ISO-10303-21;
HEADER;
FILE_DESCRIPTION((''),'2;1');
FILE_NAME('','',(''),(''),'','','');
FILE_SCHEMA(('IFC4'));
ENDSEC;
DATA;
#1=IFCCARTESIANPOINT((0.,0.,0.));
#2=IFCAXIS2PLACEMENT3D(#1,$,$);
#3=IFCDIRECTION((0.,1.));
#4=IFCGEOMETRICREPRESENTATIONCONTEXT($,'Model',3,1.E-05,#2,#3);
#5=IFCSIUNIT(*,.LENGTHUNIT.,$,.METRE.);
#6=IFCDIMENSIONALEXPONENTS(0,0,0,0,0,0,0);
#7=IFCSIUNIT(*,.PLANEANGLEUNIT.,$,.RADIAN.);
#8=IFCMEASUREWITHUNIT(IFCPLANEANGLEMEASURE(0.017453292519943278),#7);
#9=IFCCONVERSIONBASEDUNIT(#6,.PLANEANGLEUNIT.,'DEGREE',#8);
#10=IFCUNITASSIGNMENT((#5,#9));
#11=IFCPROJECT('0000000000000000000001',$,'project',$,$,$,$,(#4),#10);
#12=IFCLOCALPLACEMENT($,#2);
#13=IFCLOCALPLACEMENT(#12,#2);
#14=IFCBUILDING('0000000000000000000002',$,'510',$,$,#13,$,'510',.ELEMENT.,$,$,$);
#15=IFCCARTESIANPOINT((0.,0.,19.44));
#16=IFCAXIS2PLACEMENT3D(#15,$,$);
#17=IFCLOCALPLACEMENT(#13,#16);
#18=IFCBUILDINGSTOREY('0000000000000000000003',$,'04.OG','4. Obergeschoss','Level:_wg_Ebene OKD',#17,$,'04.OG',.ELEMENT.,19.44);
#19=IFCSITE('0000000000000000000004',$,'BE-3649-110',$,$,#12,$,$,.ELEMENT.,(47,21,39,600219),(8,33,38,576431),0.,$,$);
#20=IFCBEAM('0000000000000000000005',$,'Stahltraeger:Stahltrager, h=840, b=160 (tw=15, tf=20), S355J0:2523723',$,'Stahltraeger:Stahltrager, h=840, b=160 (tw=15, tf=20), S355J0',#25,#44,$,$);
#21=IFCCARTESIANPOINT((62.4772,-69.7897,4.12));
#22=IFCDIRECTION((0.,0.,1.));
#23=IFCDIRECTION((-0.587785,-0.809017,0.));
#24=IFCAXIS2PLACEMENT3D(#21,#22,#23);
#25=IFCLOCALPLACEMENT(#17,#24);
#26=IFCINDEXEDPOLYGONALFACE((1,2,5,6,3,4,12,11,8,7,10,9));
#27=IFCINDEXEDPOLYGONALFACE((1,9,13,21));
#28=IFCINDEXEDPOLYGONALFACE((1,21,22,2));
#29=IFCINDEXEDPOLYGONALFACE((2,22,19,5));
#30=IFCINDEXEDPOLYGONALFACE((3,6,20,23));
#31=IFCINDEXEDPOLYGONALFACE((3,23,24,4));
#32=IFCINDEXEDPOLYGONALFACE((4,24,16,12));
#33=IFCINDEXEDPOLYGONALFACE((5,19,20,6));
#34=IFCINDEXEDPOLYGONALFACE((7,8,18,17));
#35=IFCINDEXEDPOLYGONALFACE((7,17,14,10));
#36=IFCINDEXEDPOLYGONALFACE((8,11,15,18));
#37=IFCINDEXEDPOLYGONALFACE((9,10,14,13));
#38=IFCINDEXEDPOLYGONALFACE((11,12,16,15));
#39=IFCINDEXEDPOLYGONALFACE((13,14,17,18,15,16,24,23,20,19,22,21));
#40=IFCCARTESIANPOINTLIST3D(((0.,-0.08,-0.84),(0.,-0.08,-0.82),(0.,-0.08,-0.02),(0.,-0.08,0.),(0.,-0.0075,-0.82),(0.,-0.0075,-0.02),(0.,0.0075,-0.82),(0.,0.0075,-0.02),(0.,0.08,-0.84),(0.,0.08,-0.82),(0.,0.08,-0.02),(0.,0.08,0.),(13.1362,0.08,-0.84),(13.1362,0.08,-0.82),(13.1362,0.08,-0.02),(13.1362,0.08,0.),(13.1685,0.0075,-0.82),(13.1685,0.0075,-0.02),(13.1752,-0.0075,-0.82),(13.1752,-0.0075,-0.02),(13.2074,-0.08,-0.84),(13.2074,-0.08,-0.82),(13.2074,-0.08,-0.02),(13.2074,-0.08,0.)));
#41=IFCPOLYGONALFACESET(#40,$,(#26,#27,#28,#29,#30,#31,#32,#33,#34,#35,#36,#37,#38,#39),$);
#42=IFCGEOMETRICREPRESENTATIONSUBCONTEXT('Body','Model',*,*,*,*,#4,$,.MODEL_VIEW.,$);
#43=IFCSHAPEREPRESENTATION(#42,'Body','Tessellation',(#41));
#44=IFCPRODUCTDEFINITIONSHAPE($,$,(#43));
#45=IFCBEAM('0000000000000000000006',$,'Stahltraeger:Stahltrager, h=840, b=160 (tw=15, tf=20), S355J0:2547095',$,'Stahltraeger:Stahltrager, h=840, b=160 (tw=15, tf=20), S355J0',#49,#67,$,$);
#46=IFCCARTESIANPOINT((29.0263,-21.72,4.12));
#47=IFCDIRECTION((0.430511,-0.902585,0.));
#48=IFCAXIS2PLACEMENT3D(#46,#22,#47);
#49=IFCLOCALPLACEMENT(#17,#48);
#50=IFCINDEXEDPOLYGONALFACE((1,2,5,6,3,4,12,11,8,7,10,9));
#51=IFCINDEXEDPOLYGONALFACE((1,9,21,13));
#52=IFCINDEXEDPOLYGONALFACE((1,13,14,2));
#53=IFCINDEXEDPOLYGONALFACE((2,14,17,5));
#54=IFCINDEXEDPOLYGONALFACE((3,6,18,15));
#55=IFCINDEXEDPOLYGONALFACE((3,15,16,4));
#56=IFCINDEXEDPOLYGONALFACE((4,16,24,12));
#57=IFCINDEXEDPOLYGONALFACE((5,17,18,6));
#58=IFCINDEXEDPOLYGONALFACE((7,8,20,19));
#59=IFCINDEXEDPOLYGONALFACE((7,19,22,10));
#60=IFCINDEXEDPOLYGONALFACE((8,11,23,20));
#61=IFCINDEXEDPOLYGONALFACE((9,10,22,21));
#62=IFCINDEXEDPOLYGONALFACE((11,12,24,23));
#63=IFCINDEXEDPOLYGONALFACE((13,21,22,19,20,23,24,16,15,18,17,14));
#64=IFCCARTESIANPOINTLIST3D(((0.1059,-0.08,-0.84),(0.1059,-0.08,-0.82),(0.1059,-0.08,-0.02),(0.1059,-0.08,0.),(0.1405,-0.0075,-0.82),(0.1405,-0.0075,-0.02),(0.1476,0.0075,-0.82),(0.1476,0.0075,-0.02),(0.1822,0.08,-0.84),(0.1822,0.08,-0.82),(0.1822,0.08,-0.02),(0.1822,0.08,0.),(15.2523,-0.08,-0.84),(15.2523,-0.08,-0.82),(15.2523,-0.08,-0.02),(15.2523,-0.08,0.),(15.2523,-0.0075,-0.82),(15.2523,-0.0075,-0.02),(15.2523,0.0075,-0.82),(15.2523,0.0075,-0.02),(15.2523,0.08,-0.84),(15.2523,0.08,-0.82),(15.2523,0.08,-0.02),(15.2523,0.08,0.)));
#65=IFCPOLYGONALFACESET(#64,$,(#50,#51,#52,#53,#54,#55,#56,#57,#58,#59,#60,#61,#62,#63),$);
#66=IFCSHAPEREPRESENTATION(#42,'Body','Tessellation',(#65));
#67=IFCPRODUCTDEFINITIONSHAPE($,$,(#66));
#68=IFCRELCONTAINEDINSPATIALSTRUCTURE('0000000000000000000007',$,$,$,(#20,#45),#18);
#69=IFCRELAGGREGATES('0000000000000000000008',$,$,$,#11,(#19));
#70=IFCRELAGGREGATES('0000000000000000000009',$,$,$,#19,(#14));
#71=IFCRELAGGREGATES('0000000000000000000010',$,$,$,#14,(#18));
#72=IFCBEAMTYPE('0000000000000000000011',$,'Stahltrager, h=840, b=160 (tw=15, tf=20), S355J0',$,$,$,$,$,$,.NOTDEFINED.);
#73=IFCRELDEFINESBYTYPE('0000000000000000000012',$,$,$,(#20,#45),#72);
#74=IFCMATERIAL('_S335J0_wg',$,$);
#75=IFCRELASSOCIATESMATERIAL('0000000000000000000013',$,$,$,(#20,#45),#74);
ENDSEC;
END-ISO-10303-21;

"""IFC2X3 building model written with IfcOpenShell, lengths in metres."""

from ifc_helpers import new_model, entity, si_unit, converted_unit, direction, frame, frame_2d, origin, place, context, subcontext, project, spatial, i_section, extrude, clip, halfspace, material, type_object, element, save


model = new_model("IFC2X3")

# Units and contexts
model_context = context("Model", 3, precision=1e-05, world=origin(), true_north=direction((0.0, 1.0)))
body_context = subcontext(model_context, "Body", "Model", "MODEL_VIEW")
ifc_project = project(units=[si_unit("LENGTHUNIT", "METRE"), converted_unit("PLANEANGLEUNIT", "DEGREE", entity("IfcPlaneAngleMeasure", 0.017453292519943278), si_unit("PLANEANGLEUNIT", "RADIAN"), dimensions=[0, 0, 0, 0, 0, 0, 0])], contexts=[model_context])

# Site, building, storey
site_placement = place(None, origin())
site = spatial("IfcSite", under=ifc_project, at=site_placement, Name="BE-3649-110", CompositionType="ELEMENT", RefLatitude=(47, 21, 39, 600219), RefLongitude=(8, 33, 38, 576431), RefElevation=0.0)
building_placement = place(site_placement, origin())
building = spatial("IfcBuilding", under=site, at=building_placement, Name="510", LongName="510", CompositionType="ELEMENT")
storey_placement = place(building_placement, frame((0.0, 0.0, 19.44)))
storey = spatial("IfcBuildingStorey", under=building, at=storey_placement, Name="04.OG", Description="4. Obergeschoss", ObjectType="Level:_wg_Ebene OKD", LongName="04.OG", CompositionType="ELEMENT", Elevation=19.44)

# Beams
ifc_material_1 = material(Name="_S335J0_wg")
beam_type_1 = type_object("IfcBeamType", Name="Stahltrager, h=840, b=160 (tw=15, tf=20), S355J0", PredefinedType="NOTDEFINED")
beam_1_placement = place(storey_placement, frame((62.4772, -69.7897, 4.12), z_axis=(0.0, 0.0, 1.0), x_axis=(-0.587785, -0.809017, 0.0)))
element("IfcBeam", 1, at=beam_1_placement, inside=storey, type_object=beam_type_1, material=ifc_material_1, Name="Stahltraeger:Stahltrager, h=840, b=160 (tw=15, tf=20), S355J0:2523723", ObjectType="Stahltraeger:Stahltrager, h=840, b=160 (tw=15, tf=20), S355J0", context=body_context, shape_type="SweptSolid", body=[
    clip(extrude(i_section(OverallWidth=0.16, OverallDepth=0.84, WebThickness=0.015, FlangeThickness=0.02, at=frame_2d((0.0, 0.0), x_axis=(0.0, 1.0))), frame((0.0, 0.0, -0.42), z_axis=(1.0, 0.0, 0.0), x_axis=(0.0, 0.0, -1.0)), (0.0, 0.0, 1.0), 13.2074), halfspace(frame((12.8468, 0.7301, -23.78), z_axis=(0.913545, 0.406737, 0.0), x_axis=(0.406737, -0.913545, 0.0)), False)),
])
beam_2_placement = place(storey_placement, frame((29.0263, -21.72, 4.12), z_axis=(0.0, 0.0, 1.0), x_axis=(0.430511, -0.902585, 0.0)))
element("IfcBeam", 2, at=beam_2_placement, inside=storey, type_object=beam_type_1, material=ifc_material_1, Name="Stahltraeger:Stahltrager, h=840, b=160 (tw=15, tf=20), S355J0:2547095", ObjectType="Stahltraeger:Stahltrager, h=840, b=160 (tw=15, tf=20), S355J0", context=body_context, shape_type="SweptSolid", body=[
    clip(extrude(i_section(OverallWidth=0.16, OverallDepth=0.84, WebThickness=0.015, FlangeThickness=0.02, at=frame_2d((0.0, 0.0), x_axis=(0.0, 1.0))), frame((0.1059, 0.0, -0.42), z_axis=(1.0, 0.0, 0.0), x_axis=(0.0, 0.0, -1.0)), (0.0, 0.0, 1.0), 15.1464), halfspace(frame((-1.2931, -3.0131, -0.96), z_axis=(-0.902585, 0.430511, 0.0), x_axis=(0.430511, 0.902585, 0.0)), False)),
])

save(model, "model.ifc")
